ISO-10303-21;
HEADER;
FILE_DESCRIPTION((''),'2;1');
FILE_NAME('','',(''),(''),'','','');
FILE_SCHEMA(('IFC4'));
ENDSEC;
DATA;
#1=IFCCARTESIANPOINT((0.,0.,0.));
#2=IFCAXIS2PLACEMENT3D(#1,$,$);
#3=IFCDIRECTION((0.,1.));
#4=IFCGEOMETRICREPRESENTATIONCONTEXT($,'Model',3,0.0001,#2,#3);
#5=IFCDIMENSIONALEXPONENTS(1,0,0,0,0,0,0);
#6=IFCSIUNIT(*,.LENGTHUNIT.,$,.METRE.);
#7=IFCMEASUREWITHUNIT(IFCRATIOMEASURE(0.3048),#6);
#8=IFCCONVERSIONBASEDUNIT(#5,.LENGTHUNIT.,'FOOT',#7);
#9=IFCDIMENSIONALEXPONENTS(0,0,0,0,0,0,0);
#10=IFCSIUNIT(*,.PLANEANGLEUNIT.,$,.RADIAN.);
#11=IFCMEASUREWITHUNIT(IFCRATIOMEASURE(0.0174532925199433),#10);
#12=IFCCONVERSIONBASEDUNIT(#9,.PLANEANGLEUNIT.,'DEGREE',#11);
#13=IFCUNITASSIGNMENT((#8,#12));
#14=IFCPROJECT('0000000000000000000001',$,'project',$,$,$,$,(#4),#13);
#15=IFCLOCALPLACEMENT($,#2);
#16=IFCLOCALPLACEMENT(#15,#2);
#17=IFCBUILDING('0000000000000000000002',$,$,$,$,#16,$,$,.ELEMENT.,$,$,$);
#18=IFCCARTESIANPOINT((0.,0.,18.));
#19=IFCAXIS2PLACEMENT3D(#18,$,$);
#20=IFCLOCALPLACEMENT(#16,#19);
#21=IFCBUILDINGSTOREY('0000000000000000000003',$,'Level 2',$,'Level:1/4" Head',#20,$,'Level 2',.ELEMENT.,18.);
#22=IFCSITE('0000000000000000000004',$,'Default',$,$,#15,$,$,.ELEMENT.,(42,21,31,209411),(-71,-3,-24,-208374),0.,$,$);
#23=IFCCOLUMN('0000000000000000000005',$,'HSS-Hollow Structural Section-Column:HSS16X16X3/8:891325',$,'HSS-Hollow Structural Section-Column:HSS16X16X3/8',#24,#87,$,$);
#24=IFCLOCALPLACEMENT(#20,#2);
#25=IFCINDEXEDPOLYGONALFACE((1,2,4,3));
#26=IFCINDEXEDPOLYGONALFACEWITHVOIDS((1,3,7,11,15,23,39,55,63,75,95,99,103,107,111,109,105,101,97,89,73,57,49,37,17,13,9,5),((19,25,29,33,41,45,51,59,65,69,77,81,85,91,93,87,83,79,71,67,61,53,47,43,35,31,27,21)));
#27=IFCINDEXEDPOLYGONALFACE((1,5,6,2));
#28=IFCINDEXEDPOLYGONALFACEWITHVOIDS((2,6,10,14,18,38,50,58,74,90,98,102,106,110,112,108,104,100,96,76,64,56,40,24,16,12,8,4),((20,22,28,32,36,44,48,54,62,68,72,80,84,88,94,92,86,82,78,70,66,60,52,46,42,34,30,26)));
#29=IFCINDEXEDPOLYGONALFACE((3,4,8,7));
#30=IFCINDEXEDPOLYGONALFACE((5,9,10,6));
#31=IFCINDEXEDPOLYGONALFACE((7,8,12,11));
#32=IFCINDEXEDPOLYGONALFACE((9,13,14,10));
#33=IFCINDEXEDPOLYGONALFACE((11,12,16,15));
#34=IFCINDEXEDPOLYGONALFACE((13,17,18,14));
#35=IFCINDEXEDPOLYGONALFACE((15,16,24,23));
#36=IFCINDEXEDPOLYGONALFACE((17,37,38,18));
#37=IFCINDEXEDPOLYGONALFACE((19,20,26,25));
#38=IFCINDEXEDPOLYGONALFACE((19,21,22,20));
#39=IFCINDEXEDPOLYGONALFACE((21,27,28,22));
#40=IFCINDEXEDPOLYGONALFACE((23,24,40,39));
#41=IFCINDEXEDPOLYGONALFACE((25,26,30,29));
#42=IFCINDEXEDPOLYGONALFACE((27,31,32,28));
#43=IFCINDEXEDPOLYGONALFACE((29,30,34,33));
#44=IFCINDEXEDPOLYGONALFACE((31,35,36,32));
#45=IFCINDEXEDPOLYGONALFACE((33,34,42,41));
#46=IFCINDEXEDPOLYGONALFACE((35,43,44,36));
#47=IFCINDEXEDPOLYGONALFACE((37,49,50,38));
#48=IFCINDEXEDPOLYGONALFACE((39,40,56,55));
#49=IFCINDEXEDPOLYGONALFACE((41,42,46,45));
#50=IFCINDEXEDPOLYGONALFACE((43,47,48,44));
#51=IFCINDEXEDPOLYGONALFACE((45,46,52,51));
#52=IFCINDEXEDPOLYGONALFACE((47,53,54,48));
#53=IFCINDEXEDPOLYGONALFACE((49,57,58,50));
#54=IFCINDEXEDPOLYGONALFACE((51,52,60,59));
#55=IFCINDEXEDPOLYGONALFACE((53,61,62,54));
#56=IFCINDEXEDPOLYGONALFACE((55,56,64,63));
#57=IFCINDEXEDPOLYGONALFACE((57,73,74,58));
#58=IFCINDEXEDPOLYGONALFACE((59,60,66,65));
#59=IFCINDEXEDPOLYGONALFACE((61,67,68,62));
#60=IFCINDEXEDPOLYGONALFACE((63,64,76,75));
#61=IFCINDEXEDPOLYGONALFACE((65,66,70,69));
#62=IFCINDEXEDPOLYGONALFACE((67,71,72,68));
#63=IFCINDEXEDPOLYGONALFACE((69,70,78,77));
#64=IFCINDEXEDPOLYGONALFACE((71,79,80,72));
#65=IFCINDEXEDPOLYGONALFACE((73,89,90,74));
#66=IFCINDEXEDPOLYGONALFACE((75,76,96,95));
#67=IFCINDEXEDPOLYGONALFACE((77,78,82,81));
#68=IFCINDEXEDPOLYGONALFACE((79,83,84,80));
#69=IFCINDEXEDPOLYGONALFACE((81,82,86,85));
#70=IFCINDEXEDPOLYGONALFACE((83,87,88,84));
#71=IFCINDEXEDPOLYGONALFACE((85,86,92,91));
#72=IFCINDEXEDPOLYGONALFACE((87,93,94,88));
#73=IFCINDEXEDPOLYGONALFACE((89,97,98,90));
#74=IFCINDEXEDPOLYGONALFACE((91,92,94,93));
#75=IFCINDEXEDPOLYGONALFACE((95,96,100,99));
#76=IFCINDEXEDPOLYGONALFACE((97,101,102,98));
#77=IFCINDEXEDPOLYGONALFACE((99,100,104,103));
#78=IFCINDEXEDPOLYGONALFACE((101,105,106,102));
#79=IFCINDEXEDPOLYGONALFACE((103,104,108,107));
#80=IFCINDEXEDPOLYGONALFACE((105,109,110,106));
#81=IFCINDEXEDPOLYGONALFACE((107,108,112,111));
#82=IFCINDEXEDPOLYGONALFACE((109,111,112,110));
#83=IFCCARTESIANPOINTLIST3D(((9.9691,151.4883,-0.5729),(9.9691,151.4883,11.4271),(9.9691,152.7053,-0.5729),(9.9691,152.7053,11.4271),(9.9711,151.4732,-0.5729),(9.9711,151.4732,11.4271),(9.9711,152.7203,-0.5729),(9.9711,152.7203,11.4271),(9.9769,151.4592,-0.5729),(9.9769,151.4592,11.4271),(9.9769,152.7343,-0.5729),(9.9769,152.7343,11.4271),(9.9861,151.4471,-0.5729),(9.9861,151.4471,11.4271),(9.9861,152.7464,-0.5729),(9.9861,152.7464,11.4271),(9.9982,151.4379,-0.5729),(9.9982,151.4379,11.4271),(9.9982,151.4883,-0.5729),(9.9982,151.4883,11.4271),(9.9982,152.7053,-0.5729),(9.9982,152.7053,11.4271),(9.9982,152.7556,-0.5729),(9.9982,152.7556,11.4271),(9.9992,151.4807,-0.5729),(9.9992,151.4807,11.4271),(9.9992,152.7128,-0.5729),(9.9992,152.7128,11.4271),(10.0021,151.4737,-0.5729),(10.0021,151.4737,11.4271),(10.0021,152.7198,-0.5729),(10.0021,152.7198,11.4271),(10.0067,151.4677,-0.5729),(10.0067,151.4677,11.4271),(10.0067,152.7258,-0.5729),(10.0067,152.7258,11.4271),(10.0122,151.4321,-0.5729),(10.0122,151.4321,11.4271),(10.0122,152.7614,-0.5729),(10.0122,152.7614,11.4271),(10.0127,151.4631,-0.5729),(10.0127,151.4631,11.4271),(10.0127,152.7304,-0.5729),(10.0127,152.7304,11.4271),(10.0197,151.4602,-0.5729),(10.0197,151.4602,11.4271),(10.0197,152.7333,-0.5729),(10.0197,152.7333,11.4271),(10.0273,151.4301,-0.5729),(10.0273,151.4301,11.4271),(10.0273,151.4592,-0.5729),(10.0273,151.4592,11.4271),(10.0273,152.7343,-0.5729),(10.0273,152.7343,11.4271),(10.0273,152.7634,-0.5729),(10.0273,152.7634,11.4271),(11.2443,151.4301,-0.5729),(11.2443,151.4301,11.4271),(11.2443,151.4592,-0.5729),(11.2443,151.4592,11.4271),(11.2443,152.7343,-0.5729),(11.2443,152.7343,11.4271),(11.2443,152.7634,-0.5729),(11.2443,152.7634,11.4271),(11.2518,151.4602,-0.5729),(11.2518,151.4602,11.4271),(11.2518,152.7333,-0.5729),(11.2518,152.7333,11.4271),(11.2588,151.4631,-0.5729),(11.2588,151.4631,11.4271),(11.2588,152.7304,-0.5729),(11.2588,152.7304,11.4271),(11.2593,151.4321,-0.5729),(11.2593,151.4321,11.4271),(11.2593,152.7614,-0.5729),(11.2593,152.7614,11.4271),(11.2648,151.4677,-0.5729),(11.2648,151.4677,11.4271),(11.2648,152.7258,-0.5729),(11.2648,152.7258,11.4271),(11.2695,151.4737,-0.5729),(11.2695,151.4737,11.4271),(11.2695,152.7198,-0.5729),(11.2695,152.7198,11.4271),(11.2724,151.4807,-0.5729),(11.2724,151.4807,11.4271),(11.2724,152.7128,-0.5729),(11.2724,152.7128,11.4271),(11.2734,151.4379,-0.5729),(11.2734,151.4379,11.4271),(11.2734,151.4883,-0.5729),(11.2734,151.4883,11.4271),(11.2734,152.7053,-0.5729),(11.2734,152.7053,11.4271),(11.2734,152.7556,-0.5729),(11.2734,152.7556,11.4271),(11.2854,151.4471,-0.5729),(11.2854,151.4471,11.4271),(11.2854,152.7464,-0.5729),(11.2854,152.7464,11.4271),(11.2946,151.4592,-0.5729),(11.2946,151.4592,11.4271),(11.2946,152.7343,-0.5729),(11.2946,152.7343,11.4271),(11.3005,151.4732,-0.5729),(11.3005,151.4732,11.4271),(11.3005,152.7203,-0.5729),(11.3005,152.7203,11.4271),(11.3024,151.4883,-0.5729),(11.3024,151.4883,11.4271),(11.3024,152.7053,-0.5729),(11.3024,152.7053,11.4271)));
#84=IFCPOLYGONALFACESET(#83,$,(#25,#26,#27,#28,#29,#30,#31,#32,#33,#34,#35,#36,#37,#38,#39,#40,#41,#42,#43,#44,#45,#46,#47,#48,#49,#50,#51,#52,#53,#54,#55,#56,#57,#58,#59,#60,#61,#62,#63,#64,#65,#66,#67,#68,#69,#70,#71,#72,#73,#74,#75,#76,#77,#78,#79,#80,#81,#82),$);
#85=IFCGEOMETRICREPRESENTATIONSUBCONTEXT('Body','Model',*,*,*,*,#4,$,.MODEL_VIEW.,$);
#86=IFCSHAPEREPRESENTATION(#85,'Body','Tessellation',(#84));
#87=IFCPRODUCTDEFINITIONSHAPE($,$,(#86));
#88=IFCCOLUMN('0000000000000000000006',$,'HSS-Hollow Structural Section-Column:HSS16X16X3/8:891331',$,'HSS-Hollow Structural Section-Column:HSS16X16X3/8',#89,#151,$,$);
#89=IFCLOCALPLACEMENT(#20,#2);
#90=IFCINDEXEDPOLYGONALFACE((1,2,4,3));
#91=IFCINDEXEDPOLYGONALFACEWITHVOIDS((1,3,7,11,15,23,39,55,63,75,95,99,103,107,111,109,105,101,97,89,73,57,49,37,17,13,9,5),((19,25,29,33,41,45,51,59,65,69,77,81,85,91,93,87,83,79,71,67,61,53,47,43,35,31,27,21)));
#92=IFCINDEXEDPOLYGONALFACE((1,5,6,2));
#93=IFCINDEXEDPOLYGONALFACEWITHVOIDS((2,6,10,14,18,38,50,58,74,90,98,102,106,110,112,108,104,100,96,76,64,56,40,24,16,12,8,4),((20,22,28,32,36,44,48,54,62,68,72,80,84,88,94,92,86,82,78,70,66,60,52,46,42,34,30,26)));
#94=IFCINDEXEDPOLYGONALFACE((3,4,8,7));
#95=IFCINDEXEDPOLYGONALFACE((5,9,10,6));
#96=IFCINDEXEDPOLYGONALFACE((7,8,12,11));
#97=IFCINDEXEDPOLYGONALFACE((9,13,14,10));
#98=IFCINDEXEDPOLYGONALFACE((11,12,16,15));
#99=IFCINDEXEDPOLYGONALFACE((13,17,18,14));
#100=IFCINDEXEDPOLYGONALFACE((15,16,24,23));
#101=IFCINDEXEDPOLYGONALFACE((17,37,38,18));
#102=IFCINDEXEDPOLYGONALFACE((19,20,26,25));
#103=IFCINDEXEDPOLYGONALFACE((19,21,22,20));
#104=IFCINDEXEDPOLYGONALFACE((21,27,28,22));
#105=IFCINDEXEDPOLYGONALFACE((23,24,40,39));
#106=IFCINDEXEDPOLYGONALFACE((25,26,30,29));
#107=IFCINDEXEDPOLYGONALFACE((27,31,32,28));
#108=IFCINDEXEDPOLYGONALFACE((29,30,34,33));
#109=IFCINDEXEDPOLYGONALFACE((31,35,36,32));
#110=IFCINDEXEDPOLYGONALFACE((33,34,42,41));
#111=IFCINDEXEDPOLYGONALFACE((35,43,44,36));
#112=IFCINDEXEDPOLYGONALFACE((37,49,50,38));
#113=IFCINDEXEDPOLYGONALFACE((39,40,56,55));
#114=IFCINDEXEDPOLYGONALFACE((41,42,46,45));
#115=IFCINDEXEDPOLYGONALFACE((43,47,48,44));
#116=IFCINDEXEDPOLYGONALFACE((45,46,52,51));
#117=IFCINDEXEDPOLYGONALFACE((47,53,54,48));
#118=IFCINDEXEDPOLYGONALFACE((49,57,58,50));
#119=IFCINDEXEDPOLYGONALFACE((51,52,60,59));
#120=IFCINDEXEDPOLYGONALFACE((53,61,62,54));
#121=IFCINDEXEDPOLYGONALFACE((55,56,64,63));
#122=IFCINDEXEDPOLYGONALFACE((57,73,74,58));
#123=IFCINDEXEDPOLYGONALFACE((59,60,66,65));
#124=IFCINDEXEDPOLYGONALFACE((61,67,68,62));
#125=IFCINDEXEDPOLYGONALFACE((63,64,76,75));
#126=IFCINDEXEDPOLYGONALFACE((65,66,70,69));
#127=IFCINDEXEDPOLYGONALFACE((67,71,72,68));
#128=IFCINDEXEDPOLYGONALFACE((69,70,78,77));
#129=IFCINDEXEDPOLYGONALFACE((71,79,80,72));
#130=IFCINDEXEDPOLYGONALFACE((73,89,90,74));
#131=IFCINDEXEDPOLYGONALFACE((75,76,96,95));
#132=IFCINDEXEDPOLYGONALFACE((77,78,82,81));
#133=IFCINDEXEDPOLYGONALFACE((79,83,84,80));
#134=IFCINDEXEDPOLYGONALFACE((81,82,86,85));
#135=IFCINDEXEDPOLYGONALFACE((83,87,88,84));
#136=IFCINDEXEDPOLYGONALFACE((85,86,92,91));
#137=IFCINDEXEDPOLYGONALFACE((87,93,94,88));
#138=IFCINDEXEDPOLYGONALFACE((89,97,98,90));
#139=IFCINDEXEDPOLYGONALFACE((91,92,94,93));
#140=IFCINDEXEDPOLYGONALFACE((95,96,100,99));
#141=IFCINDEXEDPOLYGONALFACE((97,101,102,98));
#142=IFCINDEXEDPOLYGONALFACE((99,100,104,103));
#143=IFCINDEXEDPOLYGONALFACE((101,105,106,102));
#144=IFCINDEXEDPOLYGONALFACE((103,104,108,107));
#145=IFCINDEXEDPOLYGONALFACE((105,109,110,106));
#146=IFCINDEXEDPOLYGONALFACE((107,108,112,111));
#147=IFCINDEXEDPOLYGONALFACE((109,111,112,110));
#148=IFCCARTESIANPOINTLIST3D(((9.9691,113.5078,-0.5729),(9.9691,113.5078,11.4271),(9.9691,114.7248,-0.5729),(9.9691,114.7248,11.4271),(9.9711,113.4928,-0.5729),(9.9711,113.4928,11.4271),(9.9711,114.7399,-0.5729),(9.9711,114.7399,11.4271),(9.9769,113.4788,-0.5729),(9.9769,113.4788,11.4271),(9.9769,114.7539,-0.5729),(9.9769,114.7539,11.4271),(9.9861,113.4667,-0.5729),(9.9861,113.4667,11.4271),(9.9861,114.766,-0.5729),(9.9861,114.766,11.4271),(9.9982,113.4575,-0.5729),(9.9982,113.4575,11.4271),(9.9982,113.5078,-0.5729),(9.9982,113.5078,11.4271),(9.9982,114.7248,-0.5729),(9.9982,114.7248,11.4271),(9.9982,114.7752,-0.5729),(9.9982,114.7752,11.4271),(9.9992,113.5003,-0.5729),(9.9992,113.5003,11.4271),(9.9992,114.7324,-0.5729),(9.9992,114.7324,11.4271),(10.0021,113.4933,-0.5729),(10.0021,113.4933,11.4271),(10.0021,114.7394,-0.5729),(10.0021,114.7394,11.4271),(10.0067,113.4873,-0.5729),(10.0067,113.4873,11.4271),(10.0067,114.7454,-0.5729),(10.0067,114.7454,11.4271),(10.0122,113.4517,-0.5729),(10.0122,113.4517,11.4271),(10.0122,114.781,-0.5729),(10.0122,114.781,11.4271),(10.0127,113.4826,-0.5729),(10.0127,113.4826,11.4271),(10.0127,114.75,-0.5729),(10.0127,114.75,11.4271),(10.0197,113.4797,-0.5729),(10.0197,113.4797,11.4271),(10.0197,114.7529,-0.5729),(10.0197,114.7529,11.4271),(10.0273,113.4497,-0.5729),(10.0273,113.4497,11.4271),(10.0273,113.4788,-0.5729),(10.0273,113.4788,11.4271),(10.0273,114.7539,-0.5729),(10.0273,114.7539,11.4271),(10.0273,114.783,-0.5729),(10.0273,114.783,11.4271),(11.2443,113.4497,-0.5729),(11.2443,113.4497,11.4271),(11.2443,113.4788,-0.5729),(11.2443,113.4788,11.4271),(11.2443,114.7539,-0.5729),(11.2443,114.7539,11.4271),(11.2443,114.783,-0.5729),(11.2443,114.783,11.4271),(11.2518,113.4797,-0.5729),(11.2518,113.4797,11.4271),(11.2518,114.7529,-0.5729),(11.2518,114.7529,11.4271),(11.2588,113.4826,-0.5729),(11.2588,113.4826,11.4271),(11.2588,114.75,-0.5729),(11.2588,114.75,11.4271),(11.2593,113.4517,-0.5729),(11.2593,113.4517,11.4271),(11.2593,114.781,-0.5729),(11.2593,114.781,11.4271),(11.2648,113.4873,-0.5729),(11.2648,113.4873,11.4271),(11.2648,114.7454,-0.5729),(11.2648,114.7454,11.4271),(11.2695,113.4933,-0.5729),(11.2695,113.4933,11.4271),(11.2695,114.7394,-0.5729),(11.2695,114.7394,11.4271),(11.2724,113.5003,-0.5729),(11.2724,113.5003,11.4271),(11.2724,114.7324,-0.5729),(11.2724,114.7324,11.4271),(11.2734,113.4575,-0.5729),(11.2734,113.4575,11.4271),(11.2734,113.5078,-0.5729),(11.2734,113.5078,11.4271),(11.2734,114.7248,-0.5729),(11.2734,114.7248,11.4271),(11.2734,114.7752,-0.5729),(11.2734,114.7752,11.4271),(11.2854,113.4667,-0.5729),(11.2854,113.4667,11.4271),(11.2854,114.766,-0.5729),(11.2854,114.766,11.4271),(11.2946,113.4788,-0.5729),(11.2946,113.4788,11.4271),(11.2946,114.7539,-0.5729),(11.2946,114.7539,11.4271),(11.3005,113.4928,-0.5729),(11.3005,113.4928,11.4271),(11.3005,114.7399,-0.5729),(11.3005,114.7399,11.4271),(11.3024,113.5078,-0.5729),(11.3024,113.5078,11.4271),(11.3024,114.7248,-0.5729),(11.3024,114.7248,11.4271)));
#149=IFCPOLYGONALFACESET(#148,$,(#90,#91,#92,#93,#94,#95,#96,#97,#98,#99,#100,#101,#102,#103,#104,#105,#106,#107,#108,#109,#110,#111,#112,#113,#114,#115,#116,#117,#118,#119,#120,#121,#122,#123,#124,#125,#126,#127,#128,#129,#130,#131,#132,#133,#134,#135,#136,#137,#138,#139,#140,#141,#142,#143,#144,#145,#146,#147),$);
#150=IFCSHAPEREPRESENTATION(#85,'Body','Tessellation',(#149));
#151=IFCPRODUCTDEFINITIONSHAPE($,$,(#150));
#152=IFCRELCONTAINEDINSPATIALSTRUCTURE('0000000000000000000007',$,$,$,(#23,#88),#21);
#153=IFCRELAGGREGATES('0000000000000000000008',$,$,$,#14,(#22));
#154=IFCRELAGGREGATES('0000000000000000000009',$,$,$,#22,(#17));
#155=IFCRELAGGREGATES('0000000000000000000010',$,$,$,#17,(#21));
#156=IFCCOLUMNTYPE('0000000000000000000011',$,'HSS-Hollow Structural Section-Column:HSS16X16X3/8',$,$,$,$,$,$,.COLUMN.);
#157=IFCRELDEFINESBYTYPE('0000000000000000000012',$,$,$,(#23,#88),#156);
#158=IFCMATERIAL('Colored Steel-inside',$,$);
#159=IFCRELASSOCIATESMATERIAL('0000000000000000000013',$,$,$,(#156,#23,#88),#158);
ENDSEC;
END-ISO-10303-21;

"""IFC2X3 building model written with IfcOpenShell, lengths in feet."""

from ifc_helpers import new_model, entity, si_unit, converted_unit, direction, frame, frame_2d, origin, place, context, subcontext, project, spatial, polyline, circle_curve, parameter, trimmed, segment, composite_curve, outline, extrude, source, transform, mapped, material, type_object, type_shapes, element, save


model = new_model("IFC2X3")

# Units and contexts
model_context = context("Model", 3, precision=0.0001, world=origin(), true_north=direction((0.0, 1.0)))
body_context = subcontext(model_context, "Body", "Model", "MODEL_VIEW")
ifc_project = project(units=[converted_unit("LENGTHUNIT", "FOOT", entity("IfcRatioMeasure", 0.3048), si_unit("LENGTHUNIT", "METRE"), dimensions=[1, 0, 0, 0, 0, 0, 0]), converted_unit("PLANEANGLEUNIT", "DEGREE", entity("IfcRatioMeasure", 0.0174532925199433), si_unit("PLANEANGLEUNIT", "RADIAN"), dimensions=[0, 0, 0, 0, 0, 0, 0])], contexts=[model_context])

# Site, building, storey
site_placement = place(None, origin())
site = spatial("IfcSite", under=ifc_project, at=site_placement, Name="Default", CompositionType="ELEMENT", RefLatitude=(42, 21, 31, 209411), RefLongitude=(-71, -3, -24, -208374), RefElevation=0.0)
building_placement = place(site_placement, origin())
building = spatial("IfcBuilding", under=site, at=building_placement, CompositionType="ELEMENT")
storey_placement = place(building_placement, frame((0.0, 0.0, 18.0)))
storey = spatial("IfcBuildingStorey", under=building, at=storey_placement, Name="Level 2", ObjectType="Level:1/4\" Head", LongName="Level 2", CompositionType="ELEMENT", Elevation=18.0)

# Columns
ifc_material_1 = material(Name="Colored Steel-inside")
column_type = type_object("IfcColumnType", Name="HSS-Hollow Structural Section-Column:HSS16X16X3/8", PredefinedType="COLUMN", material=ifc_material_1)
shared_shape = source(origin(), body_context, "Body", "SweptSolid", [
    extrude(outline(composite_curve([segment(polyline([(-0.6085, -0.6667), (0.6085, -0.6667)]), True, "CONTINUOUS"), segment(trimmed(circle_curve(frame_2d((0.6085, -0.6085), x_axis=(-1.0, 0.0)), 0.0582), [parameter(90.0)], [parameter(180.0)], True, "PARAMETER"), True, "CONTINUOUS"), segment(polyline([(0.6667, -0.6085), (0.6667, 0.6085)]), True, "CONTINUOUS"), segment(trimmed(circle_curve(frame_2d((0.6085, 0.6085), x_axis=(-1.0, 0.0)), 0.0582), [parameter(180.0)], [parameter(270.0)], True, "PARAMETER"), True, "CONTINUOUS"), segment(polyline([(0.6085, 0.6667), (-0.6085, 0.6667)]), True, "CONTINUOUS"), segment(trimmed(circle_curve(frame_2d((-0.6085, 0.6085), x_axis=(-1.0, 0.0)), 0.0582), [parameter(270.0)], [parameter(360.0)], True, "PARAMETER"), True, "CONTINUOUS"), segment(polyline([(-0.6667, 0.6085), (-0.6667, -0.6085)]), True, "CONTINUOUS"), segment(trimmed(circle_curve(frame_2d((-0.6085, -0.6085), x_axis=(-1.0, 0.0)), 0.0582), [parameter(360.0)], [parameter(90.0)], True, "PARAMETER"), True, "CONTINUOUS")], self_intersect=False), holes=[composite_curve([segment(trimmed(circle_curve(frame_2d((-0.6085, -0.6085), x_axis=(-1.0, 0.0)), 0.0291), [parameter(0.0)], [parameter(90.0)], True, "PARAMETER"), False, "CONTINUOUS"), segment(polyline([(-0.6376, -0.6085), (-0.6376, 0.6085)]), True, "CONTINUOUS"), segment(trimmed(circle_curve(frame_2d((-0.6085, 0.6085), x_axis=(-1.0, 0.0)), 0.0291), [parameter(270.0)], [parameter(360.0)], True, "PARAMETER"), False, "CONTINUOUS"), segment(polyline([(-0.6085, 0.6376), (0.6085, 0.6376)]), True, "CONTINUOUS"), segment(trimmed(circle_curve(frame_2d((0.6085, 0.6085), x_axis=(-1.0, 0.0)), 0.0291), [parameter(180.0)], [parameter(270.0)], True, "PARAMETER"), False, "CONTINUOUS"), segment(polyline([(0.6376, 0.6085), (0.6376, -0.6085)]), True, "CONTINUOUS"), segment(trimmed(circle_curve(frame_2d((0.6085, -0.6085), x_axis=(-1.0, 0.0)), 0.0291), [parameter(90.0)], [parameter(180.0)], True, "PARAMETER"), False, "CONTINUOUS"), segment(polyline([(0.6085, -0.6376), (-0.6085, -0.6376)]), True, "CONTINUOUS")], self_intersect=False)]), frame((0.0, 0.0, 17.4271), z_axis=(0.0, 0.0, 1.0), x_axis=(-1.0, 0.0, 0.0)), (0.0, 0.0, 1.0), 12.0),
])
type_shapes(column_type, [shared_shape])
for number, where, name in (
    (1, (10.6358, 152.0968, -18.0), "HSS-Hollow Structural Section-Column:HSS16X16X3/8:891325"),
    (2, (10.6358, 114.1163, -18.0), "HSS-Hollow Structural Section-Column:HSS16X16X3/8:891331"),
):
    element("IfcColumn", number, at=place(storey_placement, frame(where)), inside=storey, type_object=column_type, material=ifc_material_1, Name=name, ObjectType="HSS-Hollow Structural Section-Column:HSS16X16X3/8", context=body_context, shape_type="MappedRepresentation", body=[
        mapped(shared_shape, transform((0.0, 0.0, 0.0), scale=1.0)),
    ])

save(model, "model.ifc")
